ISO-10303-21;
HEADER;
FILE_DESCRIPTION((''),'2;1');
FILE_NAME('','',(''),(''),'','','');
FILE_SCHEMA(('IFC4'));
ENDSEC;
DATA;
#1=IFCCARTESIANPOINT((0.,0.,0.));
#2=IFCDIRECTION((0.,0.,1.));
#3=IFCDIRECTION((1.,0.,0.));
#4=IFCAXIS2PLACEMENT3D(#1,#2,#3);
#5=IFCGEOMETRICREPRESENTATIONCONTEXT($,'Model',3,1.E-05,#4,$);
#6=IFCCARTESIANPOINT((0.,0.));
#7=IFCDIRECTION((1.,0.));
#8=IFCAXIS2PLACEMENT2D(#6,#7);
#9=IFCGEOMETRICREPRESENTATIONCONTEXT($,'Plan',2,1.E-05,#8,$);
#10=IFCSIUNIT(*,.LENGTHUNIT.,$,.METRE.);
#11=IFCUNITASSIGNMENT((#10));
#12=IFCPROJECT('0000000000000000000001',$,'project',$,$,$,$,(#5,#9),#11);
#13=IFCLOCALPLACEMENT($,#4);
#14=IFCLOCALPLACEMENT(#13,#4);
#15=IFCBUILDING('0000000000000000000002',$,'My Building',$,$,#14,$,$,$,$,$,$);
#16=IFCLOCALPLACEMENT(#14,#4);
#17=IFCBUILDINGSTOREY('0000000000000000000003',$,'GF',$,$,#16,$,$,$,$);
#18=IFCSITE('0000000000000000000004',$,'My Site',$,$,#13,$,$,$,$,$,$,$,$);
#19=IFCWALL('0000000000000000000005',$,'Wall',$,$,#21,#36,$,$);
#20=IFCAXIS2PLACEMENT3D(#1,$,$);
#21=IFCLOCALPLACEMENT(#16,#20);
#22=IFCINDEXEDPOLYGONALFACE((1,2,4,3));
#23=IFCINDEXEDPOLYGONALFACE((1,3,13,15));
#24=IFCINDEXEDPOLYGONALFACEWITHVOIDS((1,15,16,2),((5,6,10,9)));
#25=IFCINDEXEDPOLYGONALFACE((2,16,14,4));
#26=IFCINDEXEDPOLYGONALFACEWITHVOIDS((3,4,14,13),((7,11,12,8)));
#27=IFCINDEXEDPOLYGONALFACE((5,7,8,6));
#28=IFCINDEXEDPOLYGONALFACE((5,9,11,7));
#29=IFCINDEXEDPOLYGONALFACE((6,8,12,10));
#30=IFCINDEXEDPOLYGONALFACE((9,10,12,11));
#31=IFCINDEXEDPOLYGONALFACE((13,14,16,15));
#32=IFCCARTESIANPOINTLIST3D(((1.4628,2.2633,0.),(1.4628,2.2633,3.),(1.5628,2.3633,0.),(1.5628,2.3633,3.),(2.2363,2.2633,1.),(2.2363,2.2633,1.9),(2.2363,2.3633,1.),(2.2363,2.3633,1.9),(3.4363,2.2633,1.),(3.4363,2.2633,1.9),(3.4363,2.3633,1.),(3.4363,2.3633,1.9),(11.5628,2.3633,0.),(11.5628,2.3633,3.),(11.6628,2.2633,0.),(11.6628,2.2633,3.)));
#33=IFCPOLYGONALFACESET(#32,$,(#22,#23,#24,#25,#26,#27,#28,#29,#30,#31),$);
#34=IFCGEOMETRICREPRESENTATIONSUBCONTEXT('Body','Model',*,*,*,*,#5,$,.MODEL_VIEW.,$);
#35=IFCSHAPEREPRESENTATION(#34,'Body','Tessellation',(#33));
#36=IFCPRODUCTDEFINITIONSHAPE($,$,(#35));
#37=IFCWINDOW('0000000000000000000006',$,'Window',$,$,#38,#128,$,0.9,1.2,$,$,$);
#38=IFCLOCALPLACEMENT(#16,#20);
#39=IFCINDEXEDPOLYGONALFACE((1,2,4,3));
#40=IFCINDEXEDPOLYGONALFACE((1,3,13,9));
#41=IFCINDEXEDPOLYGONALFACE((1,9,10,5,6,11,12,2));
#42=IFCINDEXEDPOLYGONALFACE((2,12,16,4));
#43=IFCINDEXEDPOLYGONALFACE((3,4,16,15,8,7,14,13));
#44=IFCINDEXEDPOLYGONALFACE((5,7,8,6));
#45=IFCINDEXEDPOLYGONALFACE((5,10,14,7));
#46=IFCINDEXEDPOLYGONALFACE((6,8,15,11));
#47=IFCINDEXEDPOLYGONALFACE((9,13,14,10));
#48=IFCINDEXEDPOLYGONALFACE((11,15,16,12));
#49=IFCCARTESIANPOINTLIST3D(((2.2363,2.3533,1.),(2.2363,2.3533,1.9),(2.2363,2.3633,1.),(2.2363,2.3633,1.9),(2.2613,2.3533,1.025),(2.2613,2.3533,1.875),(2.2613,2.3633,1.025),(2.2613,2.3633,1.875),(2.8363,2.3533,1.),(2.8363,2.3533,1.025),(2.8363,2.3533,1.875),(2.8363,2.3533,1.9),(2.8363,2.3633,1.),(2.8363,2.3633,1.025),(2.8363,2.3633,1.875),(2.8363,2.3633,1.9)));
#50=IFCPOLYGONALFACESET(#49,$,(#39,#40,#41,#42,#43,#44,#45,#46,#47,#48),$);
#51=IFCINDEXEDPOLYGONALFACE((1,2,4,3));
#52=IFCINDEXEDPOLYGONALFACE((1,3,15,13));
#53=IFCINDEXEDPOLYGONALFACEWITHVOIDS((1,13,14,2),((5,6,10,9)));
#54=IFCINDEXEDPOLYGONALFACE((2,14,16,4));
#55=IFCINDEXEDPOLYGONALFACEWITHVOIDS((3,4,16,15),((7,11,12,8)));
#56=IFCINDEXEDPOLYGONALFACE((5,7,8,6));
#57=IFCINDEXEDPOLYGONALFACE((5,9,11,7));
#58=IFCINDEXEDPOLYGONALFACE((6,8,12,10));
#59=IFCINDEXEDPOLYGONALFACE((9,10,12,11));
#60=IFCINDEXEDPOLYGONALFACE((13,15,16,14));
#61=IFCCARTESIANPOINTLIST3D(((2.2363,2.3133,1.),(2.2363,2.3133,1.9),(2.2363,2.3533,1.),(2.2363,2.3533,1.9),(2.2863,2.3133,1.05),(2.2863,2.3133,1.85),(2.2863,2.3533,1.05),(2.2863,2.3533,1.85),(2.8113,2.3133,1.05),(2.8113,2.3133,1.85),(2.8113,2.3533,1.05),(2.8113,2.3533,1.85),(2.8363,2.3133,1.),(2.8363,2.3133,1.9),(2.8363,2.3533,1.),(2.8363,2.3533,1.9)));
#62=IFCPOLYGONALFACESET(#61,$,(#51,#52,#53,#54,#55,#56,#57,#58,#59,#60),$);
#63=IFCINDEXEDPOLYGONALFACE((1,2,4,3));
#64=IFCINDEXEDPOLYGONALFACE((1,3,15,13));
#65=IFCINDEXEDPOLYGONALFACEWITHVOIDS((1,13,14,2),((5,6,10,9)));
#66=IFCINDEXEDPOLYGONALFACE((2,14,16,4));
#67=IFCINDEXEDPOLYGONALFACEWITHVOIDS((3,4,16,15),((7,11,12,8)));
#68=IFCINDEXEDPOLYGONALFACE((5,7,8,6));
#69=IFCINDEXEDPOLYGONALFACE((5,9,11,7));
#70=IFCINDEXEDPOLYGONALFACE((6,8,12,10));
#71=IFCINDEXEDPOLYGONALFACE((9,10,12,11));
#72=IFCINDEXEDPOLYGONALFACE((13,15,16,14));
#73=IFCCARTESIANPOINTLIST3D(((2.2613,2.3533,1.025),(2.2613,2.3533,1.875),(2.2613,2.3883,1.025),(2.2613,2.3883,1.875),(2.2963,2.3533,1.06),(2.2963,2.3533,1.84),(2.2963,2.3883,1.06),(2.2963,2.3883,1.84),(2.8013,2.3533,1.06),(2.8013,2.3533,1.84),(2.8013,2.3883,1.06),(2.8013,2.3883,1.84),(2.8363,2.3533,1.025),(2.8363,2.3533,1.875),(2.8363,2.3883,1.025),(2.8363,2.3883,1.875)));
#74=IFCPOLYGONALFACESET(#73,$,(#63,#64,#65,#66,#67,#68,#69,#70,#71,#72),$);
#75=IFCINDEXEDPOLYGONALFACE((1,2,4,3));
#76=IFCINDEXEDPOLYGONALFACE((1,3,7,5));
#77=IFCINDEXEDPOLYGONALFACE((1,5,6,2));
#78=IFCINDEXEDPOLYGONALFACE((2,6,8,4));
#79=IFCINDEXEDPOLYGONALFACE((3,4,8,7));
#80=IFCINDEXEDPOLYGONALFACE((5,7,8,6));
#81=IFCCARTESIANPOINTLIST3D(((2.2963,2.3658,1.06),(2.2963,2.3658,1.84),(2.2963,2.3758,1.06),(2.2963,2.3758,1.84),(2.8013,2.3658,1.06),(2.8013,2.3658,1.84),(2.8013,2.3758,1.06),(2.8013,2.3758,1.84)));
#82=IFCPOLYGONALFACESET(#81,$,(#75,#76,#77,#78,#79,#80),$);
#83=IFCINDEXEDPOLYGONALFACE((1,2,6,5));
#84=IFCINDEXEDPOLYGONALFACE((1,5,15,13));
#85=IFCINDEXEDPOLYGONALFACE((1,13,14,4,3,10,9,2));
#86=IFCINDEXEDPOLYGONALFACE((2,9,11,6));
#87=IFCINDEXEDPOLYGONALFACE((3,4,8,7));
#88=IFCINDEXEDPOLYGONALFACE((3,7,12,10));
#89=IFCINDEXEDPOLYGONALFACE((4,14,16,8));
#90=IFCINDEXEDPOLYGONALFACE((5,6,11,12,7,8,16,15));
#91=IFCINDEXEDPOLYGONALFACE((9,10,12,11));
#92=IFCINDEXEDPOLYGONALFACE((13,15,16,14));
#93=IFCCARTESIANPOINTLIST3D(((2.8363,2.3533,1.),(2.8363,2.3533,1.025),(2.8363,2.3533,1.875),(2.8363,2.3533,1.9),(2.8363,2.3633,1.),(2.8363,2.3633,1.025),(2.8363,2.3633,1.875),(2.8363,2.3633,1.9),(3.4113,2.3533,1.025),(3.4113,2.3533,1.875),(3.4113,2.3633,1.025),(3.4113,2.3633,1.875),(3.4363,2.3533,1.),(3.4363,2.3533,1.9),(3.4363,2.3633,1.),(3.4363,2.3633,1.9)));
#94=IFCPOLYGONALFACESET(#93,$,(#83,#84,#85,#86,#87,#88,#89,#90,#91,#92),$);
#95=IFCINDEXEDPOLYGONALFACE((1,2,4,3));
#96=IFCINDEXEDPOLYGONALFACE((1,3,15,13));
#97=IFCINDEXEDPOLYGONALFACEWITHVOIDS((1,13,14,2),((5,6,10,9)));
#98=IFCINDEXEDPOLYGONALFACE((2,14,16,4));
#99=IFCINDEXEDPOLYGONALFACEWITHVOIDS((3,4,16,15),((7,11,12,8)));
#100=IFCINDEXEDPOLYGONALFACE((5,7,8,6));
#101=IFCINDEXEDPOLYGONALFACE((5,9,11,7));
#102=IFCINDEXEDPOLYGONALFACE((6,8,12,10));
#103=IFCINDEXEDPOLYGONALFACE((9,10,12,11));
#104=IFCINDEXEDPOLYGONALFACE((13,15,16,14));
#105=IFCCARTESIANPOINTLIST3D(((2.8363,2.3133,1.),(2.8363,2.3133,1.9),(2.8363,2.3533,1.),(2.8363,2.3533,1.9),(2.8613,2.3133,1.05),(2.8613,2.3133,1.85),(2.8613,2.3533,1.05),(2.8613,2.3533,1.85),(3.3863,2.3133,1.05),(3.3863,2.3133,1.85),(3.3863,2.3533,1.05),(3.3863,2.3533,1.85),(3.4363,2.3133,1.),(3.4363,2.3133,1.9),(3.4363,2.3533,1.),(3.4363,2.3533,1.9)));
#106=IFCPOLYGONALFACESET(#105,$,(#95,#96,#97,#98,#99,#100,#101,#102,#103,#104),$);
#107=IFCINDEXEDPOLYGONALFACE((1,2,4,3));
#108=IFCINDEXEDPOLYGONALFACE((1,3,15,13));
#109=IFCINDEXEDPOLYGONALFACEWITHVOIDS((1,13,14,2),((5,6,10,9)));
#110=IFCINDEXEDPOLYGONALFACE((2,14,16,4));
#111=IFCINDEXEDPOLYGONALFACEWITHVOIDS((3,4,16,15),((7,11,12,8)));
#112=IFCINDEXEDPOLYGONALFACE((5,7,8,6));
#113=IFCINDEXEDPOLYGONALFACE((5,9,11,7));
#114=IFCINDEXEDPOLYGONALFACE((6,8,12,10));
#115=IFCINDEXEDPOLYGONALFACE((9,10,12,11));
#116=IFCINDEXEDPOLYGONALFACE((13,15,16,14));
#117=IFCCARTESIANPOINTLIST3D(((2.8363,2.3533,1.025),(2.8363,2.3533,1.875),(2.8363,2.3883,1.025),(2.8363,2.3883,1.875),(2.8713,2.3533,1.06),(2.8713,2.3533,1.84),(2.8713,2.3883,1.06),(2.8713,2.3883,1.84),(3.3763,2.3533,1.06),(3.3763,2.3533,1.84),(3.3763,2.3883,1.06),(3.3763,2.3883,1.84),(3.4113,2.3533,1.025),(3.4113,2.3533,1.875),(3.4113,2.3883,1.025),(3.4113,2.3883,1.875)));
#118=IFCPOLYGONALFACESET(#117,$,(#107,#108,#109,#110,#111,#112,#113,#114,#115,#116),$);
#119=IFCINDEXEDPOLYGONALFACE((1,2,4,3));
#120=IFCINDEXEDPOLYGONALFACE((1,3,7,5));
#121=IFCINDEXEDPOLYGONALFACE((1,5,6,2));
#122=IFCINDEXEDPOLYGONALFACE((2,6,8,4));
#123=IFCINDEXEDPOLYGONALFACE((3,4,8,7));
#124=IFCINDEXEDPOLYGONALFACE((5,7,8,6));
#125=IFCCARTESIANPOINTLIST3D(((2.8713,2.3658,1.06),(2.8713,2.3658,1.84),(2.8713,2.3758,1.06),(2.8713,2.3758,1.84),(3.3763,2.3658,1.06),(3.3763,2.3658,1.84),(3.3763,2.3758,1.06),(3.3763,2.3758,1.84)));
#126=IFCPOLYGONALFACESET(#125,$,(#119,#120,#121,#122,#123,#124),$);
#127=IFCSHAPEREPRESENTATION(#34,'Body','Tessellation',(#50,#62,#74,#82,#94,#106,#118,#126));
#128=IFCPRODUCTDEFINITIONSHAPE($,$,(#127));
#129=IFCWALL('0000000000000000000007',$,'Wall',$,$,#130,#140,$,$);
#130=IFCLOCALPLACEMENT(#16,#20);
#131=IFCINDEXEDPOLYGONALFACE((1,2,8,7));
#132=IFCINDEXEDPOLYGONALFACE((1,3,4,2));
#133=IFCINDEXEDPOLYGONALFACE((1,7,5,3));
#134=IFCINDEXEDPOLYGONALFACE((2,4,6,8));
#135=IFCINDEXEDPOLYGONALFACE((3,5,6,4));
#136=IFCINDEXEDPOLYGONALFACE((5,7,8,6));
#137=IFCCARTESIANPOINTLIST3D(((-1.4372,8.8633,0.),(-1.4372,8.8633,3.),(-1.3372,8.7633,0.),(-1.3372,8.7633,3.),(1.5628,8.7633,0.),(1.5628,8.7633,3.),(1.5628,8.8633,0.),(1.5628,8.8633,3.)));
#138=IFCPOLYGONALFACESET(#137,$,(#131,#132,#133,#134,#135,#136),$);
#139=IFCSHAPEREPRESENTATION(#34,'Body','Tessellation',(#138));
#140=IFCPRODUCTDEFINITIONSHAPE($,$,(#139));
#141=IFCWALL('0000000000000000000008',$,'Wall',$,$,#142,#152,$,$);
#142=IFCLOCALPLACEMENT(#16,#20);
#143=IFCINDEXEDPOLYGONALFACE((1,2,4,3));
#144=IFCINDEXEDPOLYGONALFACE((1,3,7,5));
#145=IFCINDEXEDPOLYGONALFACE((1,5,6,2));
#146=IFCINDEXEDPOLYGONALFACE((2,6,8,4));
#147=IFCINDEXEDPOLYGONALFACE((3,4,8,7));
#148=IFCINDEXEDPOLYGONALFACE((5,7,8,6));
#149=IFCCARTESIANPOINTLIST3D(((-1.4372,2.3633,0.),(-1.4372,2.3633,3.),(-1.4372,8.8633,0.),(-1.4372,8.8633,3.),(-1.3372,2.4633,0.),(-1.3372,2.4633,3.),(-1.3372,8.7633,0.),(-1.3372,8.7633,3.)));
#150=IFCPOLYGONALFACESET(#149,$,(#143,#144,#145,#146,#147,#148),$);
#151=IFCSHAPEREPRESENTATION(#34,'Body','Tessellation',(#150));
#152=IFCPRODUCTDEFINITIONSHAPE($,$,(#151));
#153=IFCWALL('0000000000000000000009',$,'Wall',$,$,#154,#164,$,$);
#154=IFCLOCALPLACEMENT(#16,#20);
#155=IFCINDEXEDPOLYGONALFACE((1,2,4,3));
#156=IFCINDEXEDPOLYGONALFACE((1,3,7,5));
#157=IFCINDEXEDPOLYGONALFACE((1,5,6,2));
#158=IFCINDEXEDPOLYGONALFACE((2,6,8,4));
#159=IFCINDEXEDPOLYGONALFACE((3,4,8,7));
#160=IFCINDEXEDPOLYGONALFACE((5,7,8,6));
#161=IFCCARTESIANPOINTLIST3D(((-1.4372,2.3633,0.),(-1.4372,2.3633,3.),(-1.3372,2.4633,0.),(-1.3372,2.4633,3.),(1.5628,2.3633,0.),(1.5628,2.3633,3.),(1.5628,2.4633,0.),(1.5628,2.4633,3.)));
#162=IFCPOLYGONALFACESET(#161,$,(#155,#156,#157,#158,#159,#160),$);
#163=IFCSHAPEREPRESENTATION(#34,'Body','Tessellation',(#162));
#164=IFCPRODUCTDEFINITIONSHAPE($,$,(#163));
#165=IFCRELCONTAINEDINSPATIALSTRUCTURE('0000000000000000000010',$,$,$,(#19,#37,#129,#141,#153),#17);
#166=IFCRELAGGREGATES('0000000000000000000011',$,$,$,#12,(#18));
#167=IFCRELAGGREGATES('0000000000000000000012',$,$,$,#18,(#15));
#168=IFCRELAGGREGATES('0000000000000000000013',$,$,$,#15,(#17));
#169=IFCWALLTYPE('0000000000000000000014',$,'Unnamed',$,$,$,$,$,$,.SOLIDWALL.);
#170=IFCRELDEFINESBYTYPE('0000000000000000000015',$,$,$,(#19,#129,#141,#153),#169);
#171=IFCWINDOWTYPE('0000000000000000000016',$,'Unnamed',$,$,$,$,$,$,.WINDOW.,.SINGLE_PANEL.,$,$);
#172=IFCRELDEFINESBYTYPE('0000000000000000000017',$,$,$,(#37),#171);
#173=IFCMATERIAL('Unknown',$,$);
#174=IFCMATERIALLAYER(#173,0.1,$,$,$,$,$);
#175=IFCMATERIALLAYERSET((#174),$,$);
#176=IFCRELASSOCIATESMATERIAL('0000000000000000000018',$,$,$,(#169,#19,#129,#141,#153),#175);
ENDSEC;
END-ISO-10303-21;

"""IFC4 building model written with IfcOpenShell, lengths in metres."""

from ifc_helpers import new_model, entity, si_unit, frame, origin_with_axes, origin_2d_with_axis, place, context, subcontext, project, spatial, line, indexed_curve, outline, extrude, shape, source, transform, mapped, material, layer, layer_set, layer_usage, type_object, type_shapes, element, fill, save


model = new_model("IFC4")

# Units and contexts
model_context = context("Model", 3, precision=1e-05, world=origin_with_axes())
plan_context = context("Plan", 2, precision=1e-05, world=origin_2d_with_axis())
body_context_1 = subcontext(model_context, "Body", "Model", "MODEL_VIEW")
body_context_2 = subcontext(plan_context, "Body", "Plan", "PLAN_VIEW")
ifc_project = project(units=[si_unit("LENGTHUNIT", "METRE")], contexts=[model_context, plan_context])

# Site, building, storey
site_placement = place(None, origin_with_axes())
site = spatial("IfcSite", under=ifc_project, at=site_placement, Name="My Site")
building_placement = place(site_placement, origin_with_axes())
building = spatial("IfcBuilding", under=site, at=building_placement, Name="My Building")
storey_placement = place(building_placement, origin_with_axes())
storey = spatial("IfcBuildingStorey", under=building, at=storey_placement, Name="GF")

# Shared definitions
ifc_material = material(Name="Unknown")

# Shared definitions
ifc_layer_1 = layer(ifc_material, 0.1)
ifc_layer_set_1 = layer_set([ifc_layer_1])
wall_type = type_object("IfcWallType", Name="Unnamed", PredefinedType="SOLIDWALL", material=ifc_layer_set_1)

# Shared definitions
shared_shape_1 = source(origin_with_axes(), body_context_1, "Body", "SweptSolid", [
    extrude(outline(indexed_curve([(0.0, 0.0), (1.2, 0.0), (1.2, 0.9), (0.0, 0.9)], segments=[line(1, 2, 3, 4, 1)])), frame((0.0, -0.6, 0.0), z_axis=(0.0, -1.0, 0.0), x_axis=(1.0, 0.0, 0.0)), (0.0, 0.0, -1.0), 1.2),
])
window_type = type_object("IfcWindowType", Name="Unnamed", PartitioningType="SINGLE_PANEL", PredefinedType="WINDOW")
shared_shape_2 = source(origin_with_axes(), body_context_1, "Body", "SweptSolid", [
    extrude(outline(indexed_curve([(0.6, 0.0), (0.0, 0.0), (0.0, 0.9), (0.6, 0.9), (0.6, 0.875), (0.025, 0.875), (0.025, 0.025), (0.6, 0.025)], segments=[line(1, 2, 3, 4, 5, 6, 7, 8, 1)])), frame((0.0, 0.09, 0.0), z_axis=(0.0, -1.0, 0.0), x_axis=(1.0, 0.0, 0.0)), (0.0, 0.0, -1.0), 0.01),
    extrude(outline(indexed_curve([(0.0, 0.0), (0.6, 0.0), (0.6, 0.9), (0.0, 0.9)], segments=[line(1, 2, 3, 4, 1)]), holes=[indexed_curve([(0.05, 0.05), (0.575, 0.05), (0.575, 0.85), (0.05, 0.85)], segments=[line(1, 2, 3, 4, 1)])]), frame((0.0, 0.05, 0.0), z_axis=(0.0, -1.0, 0.0), x_axis=(1.0, 0.0, 0.0)), (0.0, 0.0, -1.0), 0.04),
    extrude(outline(indexed_curve([(0.0, 0.0), (0.575, 0.0), (0.575, 0.85), (0.0, 0.85)], segments=[line(1, 2, 3, 4, 1)]), holes=[indexed_curve([(0.035, 0.035), (0.54, 0.035), (0.54, 0.815), (0.035, 0.815)], segments=[line(1, 2, 3, 4, 1)])]), frame((0.025, 0.09, 0.025), z_axis=(0.0, -1.0, 0.0), x_axis=(1.0, 0.0, 0.0)), (0.0, 0.0, -1.0), 0.035),
    extrude(outline(indexed_curve([(0.035, 0.035), (0.54, 0.035), (0.54, 0.815), (0.035, 0.815)], segments=[line(1, 2, 3, 4, 1)])), frame((0.025, 0.1025, 0.025), z_axis=(0.0, -1.0, 0.0), x_axis=(1.0, 0.0, 0.0)), (0.0, 0.0, -1.0), 0.01),
    extrude(outline(indexed_curve([(0.0, 0.9), (0.6, 0.9), (0.6, 0.0), (0.0, 0.0), (0.0, 0.025), (0.575, 0.025), (0.575, 0.875), (0.0, 0.875)], segments=[line(1, 2, 3, 4, 5, 6, 7, 8, 1)])), frame((0.6, 0.09, 0.0), z_axis=(0.0, -1.0, 0.0), x_axis=(1.0, 0.0, 0.0)), (0.0, 0.0, -1.0), 0.01),
    extrude(outline(indexed_curve([(0.0, 0.0), (0.6, 0.0), (0.6, 0.9), (0.0, 0.9)], segments=[line(1, 2, 3, 4, 1)]), holes=[indexed_curve([(0.025, 0.05), (0.55, 0.05), (0.55, 0.85), (0.025, 0.85)], segments=[line(1, 2, 3, 4, 1)])]), frame((0.6, 0.05, 0.0), z_axis=(0.0, -1.0, 0.0), x_axis=(1.0, 0.0, 0.0)), (0.0, 0.0, -1.0), 0.04),
    extrude(outline(indexed_curve([(0.0, 0.0), (0.575, 0.0), (0.575, 0.85), (0.0, 0.85)], segments=[line(1, 2, 3, 4, 1)]), holes=[indexed_curve([(0.035, 0.035), (0.54, 0.035), (0.54, 0.815), (0.035, 0.815)], segments=[line(1, 2, 3, 4, 1)])]), frame((0.6, 0.09, 0.025), z_axis=(0.0, -1.0, 0.0), x_axis=(1.0, 0.0, 0.0)), (0.0, 0.0, -1.0), 0.035),
    extrude(outline(indexed_curve([(0.035, 0.035), (0.54, 0.035), (0.54, 0.815), (0.035, 0.815)], segments=[line(1, 2, 3, 4, 1)])), frame((0.6, 0.1025, 0.025), z_axis=(0.0, -1.0, 0.0), x_axis=(1.0, 0.0, 0.0)), (0.0, 0.0, -1.0), 0.01),
])
shared_shape_3 = source(origin_with_axes(), body_context_2, "Body", "Curve2D", [
    entity("IfcIndexedPolyCurve", entity("IfcCartesianPointList2D", [[0.05, 0.05], [0.575, 0.05]])),
    entity("IfcIndexedPolyCurve", entity("IfcCartesianPointList2D", [[0.0, 0.1], [0.025, 0.1], [0.025, 0.09], [0.05, 0.09], [0.05, 0.05], [0.0, 0.05]]), [entity("IfcLineIndex", [1, 2, 3, 4, 5, 6, 1])]),
    entity("IfcIndexedPolyCurve", entity("IfcCartesianPointList2D", [[0.6, 0.1], [0.6, 0.1], [0.6, 0.09], [0.575, 0.09], [0.575, 0.05], [0.6, 0.05]])),
    entity("IfcIndexedPolyCurve", entity("IfcCartesianPointList2D", [[0.025, 0.09], [0.06, 0.09], [0.06, 0.125], [0.025, 0.125]]), [entity("IfcLineIndex", [1, 2, 3, 4, 1])]),
    entity("IfcIndexedPolyCurve", entity("IfcCartesianPointList2D", [[0.6, 0.09], [0.565, 0.09], [0.565, 0.125], [0.6, 0.125]]), [entity("IfcLineIndex", [1, 2, 3, 4, 1])]),
    entity("IfcIndexedPolyCurve", entity("IfcCartesianPointList2D", [[0.06, 0.09], [0.565, 0.09]])),
    entity("IfcIndexedPolyCurve", entity("IfcCartesianPointList2D", [[0.06, 0.125], [0.565, 0.125]])),
    entity("IfcIndexedPolyCurve", entity("IfcCartesianPointList2D", [[0.06, 0.1075], [0.565, 0.1075]])),
    entity("IfcIndexedPolyCurve", entity("IfcCartesianPointList2D", [[0.625, 0.05], [1.15, 0.05]])),
    entity("IfcIndexedPolyCurve", entity("IfcCartesianPointList2D", [[0.6, 0.1], [0.6, 0.1], [0.6, 0.09], [0.625, 0.09], [0.625, 0.05], [0.6, 0.05]])),
    entity("IfcIndexedPolyCurve", entity("IfcCartesianPointList2D", [[1.2, 0.1], [1.175, 0.1], [1.175, 0.09], [1.15, 0.09], [1.15, 0.05], [1.2, 0.05]]), [entity("IfcLineIndex", [1, 2, 3, 4, 5, 6, 1])]),
    entity("IfcIndexedPolyCurve", entity("IfcCartesianPointList2D", [[0.6, 0.09], [0.635, 0.09], [0.635, 0.125], [0.6, 0.125]]), [entity("IfcLineIndex", [1, 2, 3, 4, 1])]),
    entity("IfcIndexedPolyCurve", entity("IfcCartesianPointList2D", [[1.175, 0.09], [1.14, 0.09], [1.14, 0.125], [1.175, 0.125]]), [entity("IfcLineIndex", [1, 2, 3, 4, 1])]),
    entity("IfcIndexedPolyCurve", entity("IfcCartesianPointList2D", [[0.635, 0.09], [1.14, 0.09]])),
    entity("IfcIndexedPolyCurve", entity("IfcCartesianPointList2D", [[0.635, 0.125], [1.14, 0.125]])),
    entity("IfcIndexedPolyCurve", entity("IfcCartesianPointList2D", [[0.635, 0.1075], [1.14, 0.1075]])),
])
type_shapes(window_type, [shared_shape_2, shared_shape_3])

# Wall, opening, window
ifc_layer_usage_1 = layer_usage(ifc_layer_set_1, "AXIS2", "POSITIVE", 0.0)
wall_1_placement = place(storey_placement, frame((11.5628, 2.3633, 0.0), z_axis=(0.0, 0.0, 1.0), x_axis=(-1.0, 0.0, 0.0)))
wall_1 = element("IfcWall", 1, at=wall_1_placement, inside=storey, type_object=wall_type, material=ifc_layer_usage_1, Name="Wall", context=body_context_1, shape_type="SweptSolid", body=[
    extrude(outline(indexed_curve([(0.0, 0.0), (-0.1, 0.1), (10.1, 0.1), (10.0, 0.0)], segments=[line(1, 2, 3, 4, 1)])), origin_with_axes(), (0.0, 0.0, 1.0), 3.0),
])
opening_1_placement = place(wall_1_placement, frame((9.3266, 0.1, 1.0), z_axis=(0.0, 0.0, 1.0), x_axis=(-1.0, 0.0, 0.0)))
opening_1 = element("IfcOpeningElement", 2, at=opening_1_placement, cuts=wall_1, PredefinedType="OPENING", context=body_context_1, shape_type="MappedRepresentation", body=[
    mapped(shared_shape_1, transform((0.0, 0.0, 0.0), x_axis=(1.0, 0.0, 0.0), y_axis=(0.0, 1.0, 0.0), z_axis=(0.0, 0.0, 1.0), scale=1.0)),
])
window_1_placement = place(opening_1_placement, frame((0.0, 0.0, 0.0), z_axis=(0.0, 0.0, 1.0), x_axis=(1.0, 0.0, 0.0)))
window_1 = element("IfcWindow", 3, at=window_1_placement, inside=storey, type_object=window_type, Name="Window", OverallHeight=0.9, OverallWidth=1.2, shapes=[
    shape(body_context_1, "Body", "MappedRepresentation", [mapped(shared_shape_2, transform((0.0, 0.0, 0.0), x_axis=(1.0, 0.0, 0.0), y_axis=(0.0, 1.0, 0.0), z_axis=(0.0, 0.0, 1.0), scale=1.0))]),
    shape(body_context_2, "Body", "MappedRepresentation", [mapped(shared_shape_3, transform((0.0, 0.0, 0.0), x_axis=(1.0, 0.0, 0.0), y_axis=(0.0, 1.0, 0.0), z_axis=(0.0, 0.0, 1.0), scale=1.0))]),
])
fill(opening_1, window_1)

# Walls
ifc_layer_usage_2 = layer_usage(ifc_layer_set_1, "AXIS2", "POSITIVE", 0.0)
wall_2_placement = place(storey_placement, frame((1.5628, 8.8633, 0.0), z_axis=(0.0, 0.0, 1.0), x_axis=(-1.0, 0.0, 0.0)))
element("IfcWall", 4, at=wall_2_placement, inside=storey, type_object=wall_type, material=ifc_layer_usage_2, Name="Wall", context=body_context_1, shape_type="SweptSolid", body=[
    extrude(outline(indexed_curve([(0.0, 0.0), (0.0, 0.1), (2.9, 0.1), (3.0, 0.0)], segments=[line(1, 2, 3, 4, 1)])), origin_with_axes(), (0.0, 0.0, 1.0), 3.0),
])
ifc_layer_usage_3 = layer_usage(ifc_layer_set_1, "AXIS2", "POSITIVE", 0.0)
wall_3_placement = place(storey_placement, frame((-1.4372, 8.8633, 0.0), z_axis=(0.0, 0.0, 1.0), x_axis=(0.0, -1.0, 0.0)))
element("IfcWall", 5, at=wall_3_placement, inside=storey, type_object=wall_type, material=ifc_layer_usage_3, Name="Wall", context=body_context_1, shape_type="SweptSolid", body=[
    extrude(outline(indexed_curve([(0.0, 0.0), (0.1, 0.1), (6.4, 0.1), (6.5, 0.0)], segments=[line(1, 2, 3, 4, 1)])), origin_with_axes(), (0.0, 0.0, 1.0), 3.0),
])
ifc_layer_usage_4 = layer_usage(ifc_layer_set_1, "AXIS2", "POSITIVE", 0.0)
wall_4_placement = place(storey_placement, frame((-1.4372, 2.3633, 0.0), z_axis=(0.0, 0.0, 1.0), x_axis=(1.0, 0.000001, 0.0)))
element("IfcWall", 6, at=wall_4_placement, inside=storey, type_object=wall_type, material=ifc_layer_usage_4, Name="Wall", context=body_context_1, shape_type="SweptSolid", body=[
    extrude(outline(indexed_curve([(0.0, 0.0), (0.1, 0.1), (3.0, 0.1), (3.0, 0.0)], segments=[line(1, 2, 3, 4, 1)])), origin_with_axes(), (0.0, 0.0, 1.0), 3.0),
])

save(model, "model.ifc")
